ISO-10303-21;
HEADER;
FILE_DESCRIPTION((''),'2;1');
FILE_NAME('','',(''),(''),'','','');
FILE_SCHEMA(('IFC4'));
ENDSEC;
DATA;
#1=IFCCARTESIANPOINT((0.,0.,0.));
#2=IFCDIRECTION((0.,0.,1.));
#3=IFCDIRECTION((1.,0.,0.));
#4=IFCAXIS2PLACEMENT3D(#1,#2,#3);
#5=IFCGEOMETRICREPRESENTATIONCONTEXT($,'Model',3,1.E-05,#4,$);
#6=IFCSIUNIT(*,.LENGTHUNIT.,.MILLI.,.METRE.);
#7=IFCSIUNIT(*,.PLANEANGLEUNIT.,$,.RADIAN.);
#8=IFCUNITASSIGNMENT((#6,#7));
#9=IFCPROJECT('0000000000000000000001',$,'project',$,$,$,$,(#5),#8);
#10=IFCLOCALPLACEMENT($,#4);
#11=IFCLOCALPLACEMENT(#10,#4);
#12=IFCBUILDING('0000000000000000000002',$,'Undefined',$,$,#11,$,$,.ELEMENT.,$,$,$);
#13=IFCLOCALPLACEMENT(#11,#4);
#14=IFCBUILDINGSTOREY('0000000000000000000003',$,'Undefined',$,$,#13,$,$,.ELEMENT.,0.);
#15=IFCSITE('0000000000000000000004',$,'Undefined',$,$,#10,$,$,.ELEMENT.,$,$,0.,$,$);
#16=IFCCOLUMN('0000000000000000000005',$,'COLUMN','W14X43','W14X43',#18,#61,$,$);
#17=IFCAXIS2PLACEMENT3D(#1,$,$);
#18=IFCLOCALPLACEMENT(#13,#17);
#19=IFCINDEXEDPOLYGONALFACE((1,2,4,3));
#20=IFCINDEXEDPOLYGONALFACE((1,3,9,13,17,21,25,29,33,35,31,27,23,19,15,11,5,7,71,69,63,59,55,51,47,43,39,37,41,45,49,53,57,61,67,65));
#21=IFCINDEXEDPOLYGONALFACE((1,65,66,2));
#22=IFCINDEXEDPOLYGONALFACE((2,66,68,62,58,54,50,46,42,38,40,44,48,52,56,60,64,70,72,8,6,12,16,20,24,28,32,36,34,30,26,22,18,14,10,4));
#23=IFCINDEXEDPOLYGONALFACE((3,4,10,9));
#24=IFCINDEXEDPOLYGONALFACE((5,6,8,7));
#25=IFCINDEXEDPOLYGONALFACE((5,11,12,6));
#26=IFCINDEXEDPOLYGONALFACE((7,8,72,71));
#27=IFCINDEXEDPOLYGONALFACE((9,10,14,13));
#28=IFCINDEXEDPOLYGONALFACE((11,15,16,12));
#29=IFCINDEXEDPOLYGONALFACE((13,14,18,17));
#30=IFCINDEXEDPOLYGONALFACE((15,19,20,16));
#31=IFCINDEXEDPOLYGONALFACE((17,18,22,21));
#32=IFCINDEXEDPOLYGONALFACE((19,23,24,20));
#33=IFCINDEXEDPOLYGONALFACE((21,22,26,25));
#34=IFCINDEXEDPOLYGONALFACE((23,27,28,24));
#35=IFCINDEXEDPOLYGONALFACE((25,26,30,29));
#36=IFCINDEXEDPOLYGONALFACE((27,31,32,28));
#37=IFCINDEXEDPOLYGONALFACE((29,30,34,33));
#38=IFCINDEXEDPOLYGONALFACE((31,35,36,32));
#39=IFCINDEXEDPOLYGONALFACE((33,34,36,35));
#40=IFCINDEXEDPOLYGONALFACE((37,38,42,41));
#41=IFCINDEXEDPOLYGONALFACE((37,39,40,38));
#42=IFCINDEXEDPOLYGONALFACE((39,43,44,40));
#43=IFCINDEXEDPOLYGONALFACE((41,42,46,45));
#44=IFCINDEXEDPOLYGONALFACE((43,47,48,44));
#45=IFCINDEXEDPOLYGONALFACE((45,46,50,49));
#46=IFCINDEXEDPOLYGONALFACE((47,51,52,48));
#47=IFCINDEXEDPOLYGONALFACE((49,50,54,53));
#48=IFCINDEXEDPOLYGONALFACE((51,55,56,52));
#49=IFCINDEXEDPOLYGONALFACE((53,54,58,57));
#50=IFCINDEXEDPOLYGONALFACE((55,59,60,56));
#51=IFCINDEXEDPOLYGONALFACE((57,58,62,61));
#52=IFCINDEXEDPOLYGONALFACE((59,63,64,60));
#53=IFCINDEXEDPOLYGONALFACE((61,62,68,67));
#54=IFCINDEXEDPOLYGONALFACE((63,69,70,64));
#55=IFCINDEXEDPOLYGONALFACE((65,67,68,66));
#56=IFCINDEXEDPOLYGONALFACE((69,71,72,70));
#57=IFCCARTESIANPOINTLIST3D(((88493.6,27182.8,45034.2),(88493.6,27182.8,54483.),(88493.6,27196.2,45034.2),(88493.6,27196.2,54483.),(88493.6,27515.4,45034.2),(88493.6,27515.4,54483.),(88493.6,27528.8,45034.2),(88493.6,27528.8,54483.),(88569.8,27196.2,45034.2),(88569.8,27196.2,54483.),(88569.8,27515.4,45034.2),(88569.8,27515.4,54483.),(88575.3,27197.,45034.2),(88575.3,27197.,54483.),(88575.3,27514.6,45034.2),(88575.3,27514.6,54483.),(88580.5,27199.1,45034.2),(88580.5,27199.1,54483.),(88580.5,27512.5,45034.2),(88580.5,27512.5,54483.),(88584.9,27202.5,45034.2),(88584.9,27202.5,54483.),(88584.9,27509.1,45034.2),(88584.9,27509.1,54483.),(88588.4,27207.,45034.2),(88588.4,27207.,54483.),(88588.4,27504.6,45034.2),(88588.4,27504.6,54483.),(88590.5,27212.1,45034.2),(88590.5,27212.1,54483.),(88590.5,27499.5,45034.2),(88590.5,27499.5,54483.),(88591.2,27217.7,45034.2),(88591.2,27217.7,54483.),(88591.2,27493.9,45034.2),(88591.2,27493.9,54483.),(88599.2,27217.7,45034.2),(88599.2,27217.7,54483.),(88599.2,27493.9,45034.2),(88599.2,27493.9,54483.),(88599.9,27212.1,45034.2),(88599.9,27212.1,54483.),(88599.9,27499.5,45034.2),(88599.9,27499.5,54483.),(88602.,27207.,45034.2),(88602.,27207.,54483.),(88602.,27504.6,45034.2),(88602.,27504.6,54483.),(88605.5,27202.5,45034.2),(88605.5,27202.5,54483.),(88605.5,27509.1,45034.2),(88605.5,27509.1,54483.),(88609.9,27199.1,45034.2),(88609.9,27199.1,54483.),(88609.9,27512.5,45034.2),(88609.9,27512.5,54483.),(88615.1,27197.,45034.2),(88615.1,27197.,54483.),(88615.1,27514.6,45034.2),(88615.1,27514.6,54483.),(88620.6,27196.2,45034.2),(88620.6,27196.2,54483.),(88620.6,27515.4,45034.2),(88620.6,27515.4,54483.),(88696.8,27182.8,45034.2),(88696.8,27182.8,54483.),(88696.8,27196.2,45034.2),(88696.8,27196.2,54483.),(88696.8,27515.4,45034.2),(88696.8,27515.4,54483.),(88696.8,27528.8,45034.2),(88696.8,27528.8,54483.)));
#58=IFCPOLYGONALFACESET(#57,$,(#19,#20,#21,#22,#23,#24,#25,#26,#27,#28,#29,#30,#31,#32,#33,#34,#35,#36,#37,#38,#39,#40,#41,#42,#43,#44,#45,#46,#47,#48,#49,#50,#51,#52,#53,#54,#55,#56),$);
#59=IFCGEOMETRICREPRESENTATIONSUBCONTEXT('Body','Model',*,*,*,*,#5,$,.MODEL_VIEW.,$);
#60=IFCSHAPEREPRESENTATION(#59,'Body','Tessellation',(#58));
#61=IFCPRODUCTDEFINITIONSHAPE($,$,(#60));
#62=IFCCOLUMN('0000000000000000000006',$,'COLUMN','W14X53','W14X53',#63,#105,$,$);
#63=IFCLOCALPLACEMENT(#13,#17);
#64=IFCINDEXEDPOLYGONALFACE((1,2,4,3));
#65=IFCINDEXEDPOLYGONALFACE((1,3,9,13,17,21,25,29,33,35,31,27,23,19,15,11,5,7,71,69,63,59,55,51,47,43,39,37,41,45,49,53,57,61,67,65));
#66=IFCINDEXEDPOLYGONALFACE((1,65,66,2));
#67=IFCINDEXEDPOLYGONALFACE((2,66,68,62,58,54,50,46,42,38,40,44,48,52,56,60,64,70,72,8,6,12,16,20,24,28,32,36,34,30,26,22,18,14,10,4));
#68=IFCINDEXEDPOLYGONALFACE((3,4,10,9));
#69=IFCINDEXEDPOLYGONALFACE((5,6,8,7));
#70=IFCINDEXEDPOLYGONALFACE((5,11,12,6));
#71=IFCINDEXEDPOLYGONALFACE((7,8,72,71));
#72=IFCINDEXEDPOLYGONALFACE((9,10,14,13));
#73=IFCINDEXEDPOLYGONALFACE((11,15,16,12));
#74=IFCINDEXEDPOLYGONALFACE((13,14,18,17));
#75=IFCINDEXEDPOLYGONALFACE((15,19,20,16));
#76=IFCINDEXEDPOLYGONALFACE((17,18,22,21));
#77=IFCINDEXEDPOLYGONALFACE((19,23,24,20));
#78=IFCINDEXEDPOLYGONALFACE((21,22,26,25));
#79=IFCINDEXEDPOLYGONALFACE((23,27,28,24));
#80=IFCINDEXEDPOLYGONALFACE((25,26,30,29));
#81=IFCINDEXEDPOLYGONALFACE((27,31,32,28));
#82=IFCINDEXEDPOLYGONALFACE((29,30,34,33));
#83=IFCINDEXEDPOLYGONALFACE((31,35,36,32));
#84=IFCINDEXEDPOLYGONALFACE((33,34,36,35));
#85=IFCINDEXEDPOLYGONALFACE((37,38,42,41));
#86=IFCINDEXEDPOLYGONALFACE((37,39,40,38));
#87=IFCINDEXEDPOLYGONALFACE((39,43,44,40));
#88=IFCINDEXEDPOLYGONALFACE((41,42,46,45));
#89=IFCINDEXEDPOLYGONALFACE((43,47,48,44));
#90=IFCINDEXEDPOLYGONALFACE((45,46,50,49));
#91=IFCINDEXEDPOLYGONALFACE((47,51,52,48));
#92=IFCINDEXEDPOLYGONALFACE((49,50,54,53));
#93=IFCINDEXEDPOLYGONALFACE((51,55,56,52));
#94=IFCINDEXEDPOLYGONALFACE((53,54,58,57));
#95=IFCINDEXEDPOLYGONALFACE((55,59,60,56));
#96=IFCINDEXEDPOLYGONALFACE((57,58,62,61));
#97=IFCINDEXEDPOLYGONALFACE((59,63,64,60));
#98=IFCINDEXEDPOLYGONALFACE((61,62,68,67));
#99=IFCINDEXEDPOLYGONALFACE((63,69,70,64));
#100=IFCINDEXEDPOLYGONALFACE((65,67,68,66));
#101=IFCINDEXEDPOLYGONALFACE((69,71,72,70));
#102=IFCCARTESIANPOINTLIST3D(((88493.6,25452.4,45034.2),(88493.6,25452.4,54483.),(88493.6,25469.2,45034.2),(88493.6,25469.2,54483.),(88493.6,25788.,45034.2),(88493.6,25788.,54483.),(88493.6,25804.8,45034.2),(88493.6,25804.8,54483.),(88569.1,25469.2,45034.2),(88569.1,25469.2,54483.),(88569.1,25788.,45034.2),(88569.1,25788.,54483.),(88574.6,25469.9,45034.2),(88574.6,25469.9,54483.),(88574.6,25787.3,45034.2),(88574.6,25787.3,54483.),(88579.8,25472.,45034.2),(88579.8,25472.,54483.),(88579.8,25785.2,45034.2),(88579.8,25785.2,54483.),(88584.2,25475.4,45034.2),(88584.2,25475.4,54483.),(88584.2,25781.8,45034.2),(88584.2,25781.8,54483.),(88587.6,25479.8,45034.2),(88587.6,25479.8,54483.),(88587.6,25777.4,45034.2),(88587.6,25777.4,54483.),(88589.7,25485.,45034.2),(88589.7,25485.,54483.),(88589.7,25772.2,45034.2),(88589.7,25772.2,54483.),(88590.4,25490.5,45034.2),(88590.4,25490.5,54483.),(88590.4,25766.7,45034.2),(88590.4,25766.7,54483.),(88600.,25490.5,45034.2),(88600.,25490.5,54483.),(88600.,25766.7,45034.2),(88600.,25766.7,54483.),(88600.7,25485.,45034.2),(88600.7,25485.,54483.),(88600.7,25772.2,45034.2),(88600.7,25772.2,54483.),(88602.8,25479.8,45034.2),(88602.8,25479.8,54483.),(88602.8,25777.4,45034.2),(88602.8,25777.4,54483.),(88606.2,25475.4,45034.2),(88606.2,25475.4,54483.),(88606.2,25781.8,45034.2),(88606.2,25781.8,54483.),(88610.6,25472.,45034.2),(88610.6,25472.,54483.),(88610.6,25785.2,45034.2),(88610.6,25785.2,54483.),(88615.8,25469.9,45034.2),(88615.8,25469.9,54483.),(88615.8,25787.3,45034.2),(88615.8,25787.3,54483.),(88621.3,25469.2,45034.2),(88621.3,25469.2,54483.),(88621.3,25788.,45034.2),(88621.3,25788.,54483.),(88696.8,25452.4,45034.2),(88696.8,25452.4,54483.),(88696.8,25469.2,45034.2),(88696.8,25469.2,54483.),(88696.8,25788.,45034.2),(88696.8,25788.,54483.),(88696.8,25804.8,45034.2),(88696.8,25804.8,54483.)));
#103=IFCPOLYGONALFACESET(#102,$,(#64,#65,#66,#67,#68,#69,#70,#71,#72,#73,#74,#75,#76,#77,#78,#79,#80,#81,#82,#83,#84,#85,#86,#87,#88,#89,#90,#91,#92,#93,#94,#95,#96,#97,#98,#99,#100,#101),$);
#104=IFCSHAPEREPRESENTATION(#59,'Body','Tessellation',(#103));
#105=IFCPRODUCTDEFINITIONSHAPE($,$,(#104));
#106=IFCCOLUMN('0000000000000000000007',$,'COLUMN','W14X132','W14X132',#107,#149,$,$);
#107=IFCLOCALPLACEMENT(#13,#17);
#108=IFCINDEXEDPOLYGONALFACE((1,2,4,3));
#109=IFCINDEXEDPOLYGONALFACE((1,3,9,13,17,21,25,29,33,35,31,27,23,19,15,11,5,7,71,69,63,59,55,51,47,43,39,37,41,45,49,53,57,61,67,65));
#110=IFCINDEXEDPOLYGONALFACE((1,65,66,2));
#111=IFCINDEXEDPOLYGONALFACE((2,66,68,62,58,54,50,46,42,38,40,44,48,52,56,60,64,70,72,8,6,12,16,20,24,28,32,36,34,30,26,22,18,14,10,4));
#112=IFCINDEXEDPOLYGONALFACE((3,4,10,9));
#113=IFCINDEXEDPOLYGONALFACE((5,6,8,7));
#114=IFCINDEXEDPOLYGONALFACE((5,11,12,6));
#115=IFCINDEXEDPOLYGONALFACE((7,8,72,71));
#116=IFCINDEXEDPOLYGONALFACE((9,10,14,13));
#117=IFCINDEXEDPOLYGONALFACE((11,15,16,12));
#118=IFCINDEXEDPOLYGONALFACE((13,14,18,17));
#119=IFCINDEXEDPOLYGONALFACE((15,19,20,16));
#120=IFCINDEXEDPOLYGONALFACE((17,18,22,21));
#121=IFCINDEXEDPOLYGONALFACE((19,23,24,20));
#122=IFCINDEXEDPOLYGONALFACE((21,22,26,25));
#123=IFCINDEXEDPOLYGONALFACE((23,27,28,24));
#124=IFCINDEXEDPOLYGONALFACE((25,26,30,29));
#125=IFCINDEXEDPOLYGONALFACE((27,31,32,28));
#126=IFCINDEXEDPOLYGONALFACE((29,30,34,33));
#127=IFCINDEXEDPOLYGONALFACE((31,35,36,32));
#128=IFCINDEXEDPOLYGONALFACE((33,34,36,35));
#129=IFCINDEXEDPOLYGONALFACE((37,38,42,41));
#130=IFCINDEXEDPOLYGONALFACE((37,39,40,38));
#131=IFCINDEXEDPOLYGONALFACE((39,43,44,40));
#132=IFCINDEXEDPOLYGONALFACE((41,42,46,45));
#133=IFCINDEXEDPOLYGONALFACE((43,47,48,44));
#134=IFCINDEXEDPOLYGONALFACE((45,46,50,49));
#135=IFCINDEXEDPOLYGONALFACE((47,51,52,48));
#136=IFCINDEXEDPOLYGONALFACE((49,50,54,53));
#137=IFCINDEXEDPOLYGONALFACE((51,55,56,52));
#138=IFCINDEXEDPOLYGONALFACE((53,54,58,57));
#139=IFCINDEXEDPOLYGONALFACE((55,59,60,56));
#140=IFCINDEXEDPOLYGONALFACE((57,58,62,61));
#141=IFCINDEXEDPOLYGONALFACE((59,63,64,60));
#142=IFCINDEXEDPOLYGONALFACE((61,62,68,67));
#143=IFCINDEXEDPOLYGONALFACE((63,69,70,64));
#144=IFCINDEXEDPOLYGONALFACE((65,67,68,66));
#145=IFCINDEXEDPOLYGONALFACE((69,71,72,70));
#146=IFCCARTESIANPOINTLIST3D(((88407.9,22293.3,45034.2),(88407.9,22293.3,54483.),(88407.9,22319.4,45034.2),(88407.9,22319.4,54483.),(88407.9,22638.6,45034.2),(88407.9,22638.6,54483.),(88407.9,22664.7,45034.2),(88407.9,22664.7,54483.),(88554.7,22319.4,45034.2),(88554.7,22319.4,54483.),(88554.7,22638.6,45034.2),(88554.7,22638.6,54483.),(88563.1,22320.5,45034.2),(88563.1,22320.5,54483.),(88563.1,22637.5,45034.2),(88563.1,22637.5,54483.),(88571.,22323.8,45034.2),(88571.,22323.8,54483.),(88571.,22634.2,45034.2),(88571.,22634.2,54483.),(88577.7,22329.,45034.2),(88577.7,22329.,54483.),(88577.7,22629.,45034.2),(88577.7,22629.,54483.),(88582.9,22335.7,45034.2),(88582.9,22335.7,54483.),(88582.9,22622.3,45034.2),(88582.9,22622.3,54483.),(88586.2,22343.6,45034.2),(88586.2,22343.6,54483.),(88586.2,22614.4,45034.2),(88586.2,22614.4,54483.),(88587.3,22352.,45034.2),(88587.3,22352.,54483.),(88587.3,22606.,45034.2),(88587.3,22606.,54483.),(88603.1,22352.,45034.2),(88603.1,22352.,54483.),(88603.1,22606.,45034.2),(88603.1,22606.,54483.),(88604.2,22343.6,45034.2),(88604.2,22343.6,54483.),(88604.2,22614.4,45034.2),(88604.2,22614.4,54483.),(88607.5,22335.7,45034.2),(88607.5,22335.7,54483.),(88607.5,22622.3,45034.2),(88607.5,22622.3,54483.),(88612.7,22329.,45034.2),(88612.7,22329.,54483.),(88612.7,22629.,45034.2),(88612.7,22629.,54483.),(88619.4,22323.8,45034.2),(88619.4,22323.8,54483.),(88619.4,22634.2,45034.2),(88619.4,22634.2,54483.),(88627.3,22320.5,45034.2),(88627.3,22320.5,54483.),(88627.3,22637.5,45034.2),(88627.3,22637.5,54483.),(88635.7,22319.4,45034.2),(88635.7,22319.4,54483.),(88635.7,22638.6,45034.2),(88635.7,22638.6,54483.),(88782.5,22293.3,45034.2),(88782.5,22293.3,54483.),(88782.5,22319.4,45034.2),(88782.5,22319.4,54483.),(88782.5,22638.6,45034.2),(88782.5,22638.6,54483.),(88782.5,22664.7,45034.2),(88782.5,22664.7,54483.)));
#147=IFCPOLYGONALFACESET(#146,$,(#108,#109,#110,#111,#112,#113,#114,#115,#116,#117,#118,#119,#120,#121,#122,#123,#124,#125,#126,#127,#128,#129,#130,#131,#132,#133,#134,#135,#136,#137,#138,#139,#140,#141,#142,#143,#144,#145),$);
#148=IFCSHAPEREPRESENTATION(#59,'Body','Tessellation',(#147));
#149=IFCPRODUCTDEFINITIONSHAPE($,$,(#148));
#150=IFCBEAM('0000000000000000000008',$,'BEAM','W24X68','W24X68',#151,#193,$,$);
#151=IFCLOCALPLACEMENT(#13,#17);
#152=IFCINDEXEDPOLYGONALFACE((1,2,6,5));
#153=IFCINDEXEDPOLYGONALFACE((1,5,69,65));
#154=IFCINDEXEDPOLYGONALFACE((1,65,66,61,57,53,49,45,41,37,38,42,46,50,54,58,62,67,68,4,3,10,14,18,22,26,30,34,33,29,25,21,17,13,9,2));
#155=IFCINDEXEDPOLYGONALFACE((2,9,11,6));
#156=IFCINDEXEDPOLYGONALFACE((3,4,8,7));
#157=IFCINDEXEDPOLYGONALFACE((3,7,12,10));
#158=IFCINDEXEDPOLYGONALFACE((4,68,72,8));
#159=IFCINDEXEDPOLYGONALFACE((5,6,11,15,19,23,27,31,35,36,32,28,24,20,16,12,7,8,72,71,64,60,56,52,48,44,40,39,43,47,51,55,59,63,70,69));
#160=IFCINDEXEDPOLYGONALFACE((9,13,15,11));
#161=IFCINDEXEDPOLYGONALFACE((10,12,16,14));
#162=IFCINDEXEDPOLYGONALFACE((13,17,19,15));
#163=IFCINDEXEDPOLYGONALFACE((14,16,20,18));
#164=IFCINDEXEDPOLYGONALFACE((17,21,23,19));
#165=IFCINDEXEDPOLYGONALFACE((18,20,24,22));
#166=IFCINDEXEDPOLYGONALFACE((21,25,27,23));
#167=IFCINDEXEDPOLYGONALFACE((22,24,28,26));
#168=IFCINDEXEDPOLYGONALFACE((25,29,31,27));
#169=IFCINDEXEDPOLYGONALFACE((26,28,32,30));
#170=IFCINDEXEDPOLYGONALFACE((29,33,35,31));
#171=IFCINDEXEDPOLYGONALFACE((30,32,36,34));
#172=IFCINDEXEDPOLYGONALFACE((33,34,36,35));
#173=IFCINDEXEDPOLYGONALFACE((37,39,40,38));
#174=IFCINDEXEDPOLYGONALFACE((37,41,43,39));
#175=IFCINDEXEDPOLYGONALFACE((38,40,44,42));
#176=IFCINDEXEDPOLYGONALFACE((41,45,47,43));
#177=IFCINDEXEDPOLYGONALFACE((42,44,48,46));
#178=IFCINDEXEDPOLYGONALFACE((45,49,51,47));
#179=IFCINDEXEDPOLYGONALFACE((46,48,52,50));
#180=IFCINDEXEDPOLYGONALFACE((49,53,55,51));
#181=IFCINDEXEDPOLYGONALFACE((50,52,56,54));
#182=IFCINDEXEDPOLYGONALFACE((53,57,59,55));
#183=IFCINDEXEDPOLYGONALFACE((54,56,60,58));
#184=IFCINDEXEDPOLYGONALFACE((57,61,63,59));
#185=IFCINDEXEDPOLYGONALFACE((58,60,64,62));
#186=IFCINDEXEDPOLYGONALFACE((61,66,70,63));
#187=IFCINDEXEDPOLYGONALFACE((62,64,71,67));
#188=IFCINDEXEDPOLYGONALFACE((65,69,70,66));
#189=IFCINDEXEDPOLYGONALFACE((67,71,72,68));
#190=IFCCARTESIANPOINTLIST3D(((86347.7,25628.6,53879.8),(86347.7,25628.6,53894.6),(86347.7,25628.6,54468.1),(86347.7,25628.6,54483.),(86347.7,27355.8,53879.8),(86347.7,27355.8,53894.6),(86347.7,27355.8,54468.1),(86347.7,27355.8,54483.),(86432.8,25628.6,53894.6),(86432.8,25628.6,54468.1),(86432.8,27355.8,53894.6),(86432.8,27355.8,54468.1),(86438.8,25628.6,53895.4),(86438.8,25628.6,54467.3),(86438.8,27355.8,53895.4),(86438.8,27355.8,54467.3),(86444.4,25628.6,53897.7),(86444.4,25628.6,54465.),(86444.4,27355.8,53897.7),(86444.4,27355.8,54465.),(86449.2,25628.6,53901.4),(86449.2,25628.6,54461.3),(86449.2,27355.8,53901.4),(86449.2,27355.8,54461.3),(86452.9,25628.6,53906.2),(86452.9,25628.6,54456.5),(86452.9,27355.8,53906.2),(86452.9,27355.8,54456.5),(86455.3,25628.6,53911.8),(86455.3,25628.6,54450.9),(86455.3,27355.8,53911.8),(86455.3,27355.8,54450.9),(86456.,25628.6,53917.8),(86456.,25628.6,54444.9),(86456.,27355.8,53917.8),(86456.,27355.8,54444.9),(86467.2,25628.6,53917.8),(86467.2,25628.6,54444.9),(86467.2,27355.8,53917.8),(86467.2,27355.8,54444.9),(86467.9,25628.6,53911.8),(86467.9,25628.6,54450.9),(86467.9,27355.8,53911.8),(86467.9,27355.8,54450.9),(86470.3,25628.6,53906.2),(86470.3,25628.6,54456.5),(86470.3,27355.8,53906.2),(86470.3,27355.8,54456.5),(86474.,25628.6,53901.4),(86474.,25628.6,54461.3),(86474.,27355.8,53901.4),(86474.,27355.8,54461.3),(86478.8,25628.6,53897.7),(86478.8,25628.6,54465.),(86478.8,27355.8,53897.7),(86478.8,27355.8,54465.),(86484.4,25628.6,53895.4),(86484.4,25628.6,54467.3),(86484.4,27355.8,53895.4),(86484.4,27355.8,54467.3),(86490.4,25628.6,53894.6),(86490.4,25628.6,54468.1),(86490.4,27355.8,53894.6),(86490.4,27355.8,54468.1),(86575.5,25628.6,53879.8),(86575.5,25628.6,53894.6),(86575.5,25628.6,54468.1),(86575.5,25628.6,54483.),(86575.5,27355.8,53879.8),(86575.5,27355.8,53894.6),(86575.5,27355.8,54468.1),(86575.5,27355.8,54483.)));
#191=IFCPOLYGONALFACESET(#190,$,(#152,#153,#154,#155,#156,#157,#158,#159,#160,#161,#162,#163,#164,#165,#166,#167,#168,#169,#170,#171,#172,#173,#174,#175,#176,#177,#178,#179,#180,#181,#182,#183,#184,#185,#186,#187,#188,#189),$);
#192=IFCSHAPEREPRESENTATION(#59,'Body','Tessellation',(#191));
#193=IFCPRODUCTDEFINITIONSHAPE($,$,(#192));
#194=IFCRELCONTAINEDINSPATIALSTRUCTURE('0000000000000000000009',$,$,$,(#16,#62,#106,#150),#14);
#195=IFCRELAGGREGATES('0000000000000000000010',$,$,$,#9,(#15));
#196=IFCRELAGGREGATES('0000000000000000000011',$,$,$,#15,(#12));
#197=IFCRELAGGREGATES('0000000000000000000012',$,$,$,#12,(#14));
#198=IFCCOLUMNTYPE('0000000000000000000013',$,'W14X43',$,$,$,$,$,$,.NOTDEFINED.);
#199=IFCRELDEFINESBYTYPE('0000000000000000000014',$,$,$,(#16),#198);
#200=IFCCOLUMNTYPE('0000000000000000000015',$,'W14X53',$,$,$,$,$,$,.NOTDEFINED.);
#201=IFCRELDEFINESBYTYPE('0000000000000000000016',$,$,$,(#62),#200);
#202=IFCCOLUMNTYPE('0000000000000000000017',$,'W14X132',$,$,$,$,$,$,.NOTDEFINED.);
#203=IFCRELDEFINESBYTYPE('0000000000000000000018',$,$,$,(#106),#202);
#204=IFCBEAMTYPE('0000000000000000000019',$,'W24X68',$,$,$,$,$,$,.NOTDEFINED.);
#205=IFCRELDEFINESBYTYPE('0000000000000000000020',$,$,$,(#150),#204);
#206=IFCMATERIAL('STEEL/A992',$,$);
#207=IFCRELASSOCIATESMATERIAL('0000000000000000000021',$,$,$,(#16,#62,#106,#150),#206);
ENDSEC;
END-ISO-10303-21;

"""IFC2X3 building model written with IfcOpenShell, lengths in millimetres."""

from ifc_helpers import new_model, si_unit, frame, origin_with_axes, origin_2d_with_axis, place, context, subcontext, project, spatial, i_section, extrude, material, type_object, element, save


model = new_model("IFC2X3")

# Units and contexts
model_context = context("Model", 3, precision=1e-05, world=origin_with_axes())
body_context = subcontext(model_context, "Body", "Model", "MODEL_VIEW")
ifc_project = project(units=[si_unit("LENGTHUNIT", "METRE", prefix="MILLI"), si_unit("PLANEANGLEUNIT", "RADIAN")], contexts=[model_context])

# Site, building, storey
site_placement = place(None, origin_with_axes())
site = spatial("IfcSite", under=ifc_project, at=site_placement, Name="Undefined", CompositionType="ELEMENT", RefElevation=0.0)
building_placement = place(site_placement, origin_with_axes())
building = spatial("IfcBuilding", under=site, at=building_placement, Name="Undefined", CompositionType="ELEMENT")
storey_placement = place(building_placement, origin_with_axes())
storey = spatial("IfcBuildingStorey", under=building, at=storey_placement, Name="Undefined", CompositionType="ELEMENT", Elevation=0.0)

# Columns
ifc_material = material(Name="STEEL/A992")
column_type_1 = type_object("IfcColumnType", Name="W14X43", PredefinedType="NOTDEFINED")
column_1_placement = place(storey_placement, frame((88595.2, 27355.8, 45034.2), z_axis=(0.0, 0.0, 1.0), x_axis=(1.0, 0.0, 0.0)))
element("IfcColumn", 1, at=column_1_placement, inside=storey, type_object=column_type_1, material=ifc_material, Name="COLUMN", Description="W14X43", ObjectType="W14X43", context=body_context, shape_type="SweptSolid", body=[
    extrude(i_section(OverallWidth=203.2, OverallDepth=346.1, WebThickness=7.9, FlangeThickness=13.5, FilletRadius=21.5, at=origin_2d_with_axis()), frame((0.0, 0.0, 9448.8), z_axis=(0.0, 0.0, -1.0), x_axis=(-1.0, 0.0, 0.0)), (0.0, 0.0, 1.0), 9448.8),
])
column_type_2 = type_object("IfcColumnType", Name="W14X53", PredefinedType="NOTDEFINED")
column_2_placement = place(storey_placement, frame((88595.2, 25628.6, 45034.2), z_axis=(0.0, 0.0, 1.0), x_axis=(1.0, 0.0, 0.0)))
element("IfcColumn", 2, at=column_2_placement, inside=storey, type_object=column_type_2, material=ifc_material, Name="COLUMN", Description="W14X53", ObjectType="W14X53", context=body_context, shape_type="SweptSolid", body=[
    extrude(i_section(OverallWidth=203.2, OverallDepth=352.4, WebThickness=9.5, FlangeThickness=16.8, FilletRadius=21.3, at=origin_2d_with_axis()), frame((0.0, 0.0, 9448.8), z_axis=(0.0, 0.0, -1.0), x_axis=(-1.0, 0.0, 0.0)), (0.0, 0.0, 1.0), 9448.8),
])
column_type_3 = type_object("IfcColumnType", Name="W14X132", PredefinedType="NOTDEFINED")
column_3_placement = place(storey_placement, frame((88595.2, 22479.0, 45034.2), z_axis=(0.0, 0.0, 1.0), x_axis=(1.0, 0.0, 0.0)))
element("IfcColumn", 3, at=column_3_placement, inside=storey, type_object=column_type_3, material=ifc_material, Name="COLUMN", Description="W14X132", ObjectType="W14X132", context=body_context, shape_type="SweptSolid", body=[
    extrude(i_section(OverallWidth=374.6, OverallDepth=371.5, WebThickness=15.9, FlangeThickness=26.2, FilletRadius=32.6, at=origin_2d_with_axis()), frame((0.0, 0.0, 9448.8), z_axis=(0.0, 0.0, -1.0), x_axis=(-1.0, 0.0, 0.0)), (0.0, 0.0, 1.0), 9448.8),
])

# Beam
beam_type = type_object("IfcBeamType", Name="W24X68", PredefinedType="NOTDEFINED")
for number, where, z_axis, x_axis, name in (
    (4, (86461.6, 25628.6, 54181.4), (0.0, 0.0, 1.0), (0.0, 1.0, 0.0), "BEAM"),
):
    element("IfcBeam", number, at=place(storey_placement, frame(where, z_axis=z_axis, x_axis=x_axis)), inside=storey, type_object=beam_type, material=ifc_material, Name=name, Description="W24X68", ObjectType="W24X68", context=body_context, shape_type="SweptSolid", body=[
        extrude(i_section(OverallWidth=227.8, OverallDepth=603.2, WebThickness=11.1, FlangeThickness=14.9, FilletRadius=23.2, at=origin_2d_with_axis()), frame((1727.2, 0.0, 0.0), z_axis=(-1.0, 0.0, 0.0), x_axis=(0.0, -1.0, 0.0)), (0.0, 0.0, 1.0), 1727.2),
    ])

save(model, "model.ifc")
